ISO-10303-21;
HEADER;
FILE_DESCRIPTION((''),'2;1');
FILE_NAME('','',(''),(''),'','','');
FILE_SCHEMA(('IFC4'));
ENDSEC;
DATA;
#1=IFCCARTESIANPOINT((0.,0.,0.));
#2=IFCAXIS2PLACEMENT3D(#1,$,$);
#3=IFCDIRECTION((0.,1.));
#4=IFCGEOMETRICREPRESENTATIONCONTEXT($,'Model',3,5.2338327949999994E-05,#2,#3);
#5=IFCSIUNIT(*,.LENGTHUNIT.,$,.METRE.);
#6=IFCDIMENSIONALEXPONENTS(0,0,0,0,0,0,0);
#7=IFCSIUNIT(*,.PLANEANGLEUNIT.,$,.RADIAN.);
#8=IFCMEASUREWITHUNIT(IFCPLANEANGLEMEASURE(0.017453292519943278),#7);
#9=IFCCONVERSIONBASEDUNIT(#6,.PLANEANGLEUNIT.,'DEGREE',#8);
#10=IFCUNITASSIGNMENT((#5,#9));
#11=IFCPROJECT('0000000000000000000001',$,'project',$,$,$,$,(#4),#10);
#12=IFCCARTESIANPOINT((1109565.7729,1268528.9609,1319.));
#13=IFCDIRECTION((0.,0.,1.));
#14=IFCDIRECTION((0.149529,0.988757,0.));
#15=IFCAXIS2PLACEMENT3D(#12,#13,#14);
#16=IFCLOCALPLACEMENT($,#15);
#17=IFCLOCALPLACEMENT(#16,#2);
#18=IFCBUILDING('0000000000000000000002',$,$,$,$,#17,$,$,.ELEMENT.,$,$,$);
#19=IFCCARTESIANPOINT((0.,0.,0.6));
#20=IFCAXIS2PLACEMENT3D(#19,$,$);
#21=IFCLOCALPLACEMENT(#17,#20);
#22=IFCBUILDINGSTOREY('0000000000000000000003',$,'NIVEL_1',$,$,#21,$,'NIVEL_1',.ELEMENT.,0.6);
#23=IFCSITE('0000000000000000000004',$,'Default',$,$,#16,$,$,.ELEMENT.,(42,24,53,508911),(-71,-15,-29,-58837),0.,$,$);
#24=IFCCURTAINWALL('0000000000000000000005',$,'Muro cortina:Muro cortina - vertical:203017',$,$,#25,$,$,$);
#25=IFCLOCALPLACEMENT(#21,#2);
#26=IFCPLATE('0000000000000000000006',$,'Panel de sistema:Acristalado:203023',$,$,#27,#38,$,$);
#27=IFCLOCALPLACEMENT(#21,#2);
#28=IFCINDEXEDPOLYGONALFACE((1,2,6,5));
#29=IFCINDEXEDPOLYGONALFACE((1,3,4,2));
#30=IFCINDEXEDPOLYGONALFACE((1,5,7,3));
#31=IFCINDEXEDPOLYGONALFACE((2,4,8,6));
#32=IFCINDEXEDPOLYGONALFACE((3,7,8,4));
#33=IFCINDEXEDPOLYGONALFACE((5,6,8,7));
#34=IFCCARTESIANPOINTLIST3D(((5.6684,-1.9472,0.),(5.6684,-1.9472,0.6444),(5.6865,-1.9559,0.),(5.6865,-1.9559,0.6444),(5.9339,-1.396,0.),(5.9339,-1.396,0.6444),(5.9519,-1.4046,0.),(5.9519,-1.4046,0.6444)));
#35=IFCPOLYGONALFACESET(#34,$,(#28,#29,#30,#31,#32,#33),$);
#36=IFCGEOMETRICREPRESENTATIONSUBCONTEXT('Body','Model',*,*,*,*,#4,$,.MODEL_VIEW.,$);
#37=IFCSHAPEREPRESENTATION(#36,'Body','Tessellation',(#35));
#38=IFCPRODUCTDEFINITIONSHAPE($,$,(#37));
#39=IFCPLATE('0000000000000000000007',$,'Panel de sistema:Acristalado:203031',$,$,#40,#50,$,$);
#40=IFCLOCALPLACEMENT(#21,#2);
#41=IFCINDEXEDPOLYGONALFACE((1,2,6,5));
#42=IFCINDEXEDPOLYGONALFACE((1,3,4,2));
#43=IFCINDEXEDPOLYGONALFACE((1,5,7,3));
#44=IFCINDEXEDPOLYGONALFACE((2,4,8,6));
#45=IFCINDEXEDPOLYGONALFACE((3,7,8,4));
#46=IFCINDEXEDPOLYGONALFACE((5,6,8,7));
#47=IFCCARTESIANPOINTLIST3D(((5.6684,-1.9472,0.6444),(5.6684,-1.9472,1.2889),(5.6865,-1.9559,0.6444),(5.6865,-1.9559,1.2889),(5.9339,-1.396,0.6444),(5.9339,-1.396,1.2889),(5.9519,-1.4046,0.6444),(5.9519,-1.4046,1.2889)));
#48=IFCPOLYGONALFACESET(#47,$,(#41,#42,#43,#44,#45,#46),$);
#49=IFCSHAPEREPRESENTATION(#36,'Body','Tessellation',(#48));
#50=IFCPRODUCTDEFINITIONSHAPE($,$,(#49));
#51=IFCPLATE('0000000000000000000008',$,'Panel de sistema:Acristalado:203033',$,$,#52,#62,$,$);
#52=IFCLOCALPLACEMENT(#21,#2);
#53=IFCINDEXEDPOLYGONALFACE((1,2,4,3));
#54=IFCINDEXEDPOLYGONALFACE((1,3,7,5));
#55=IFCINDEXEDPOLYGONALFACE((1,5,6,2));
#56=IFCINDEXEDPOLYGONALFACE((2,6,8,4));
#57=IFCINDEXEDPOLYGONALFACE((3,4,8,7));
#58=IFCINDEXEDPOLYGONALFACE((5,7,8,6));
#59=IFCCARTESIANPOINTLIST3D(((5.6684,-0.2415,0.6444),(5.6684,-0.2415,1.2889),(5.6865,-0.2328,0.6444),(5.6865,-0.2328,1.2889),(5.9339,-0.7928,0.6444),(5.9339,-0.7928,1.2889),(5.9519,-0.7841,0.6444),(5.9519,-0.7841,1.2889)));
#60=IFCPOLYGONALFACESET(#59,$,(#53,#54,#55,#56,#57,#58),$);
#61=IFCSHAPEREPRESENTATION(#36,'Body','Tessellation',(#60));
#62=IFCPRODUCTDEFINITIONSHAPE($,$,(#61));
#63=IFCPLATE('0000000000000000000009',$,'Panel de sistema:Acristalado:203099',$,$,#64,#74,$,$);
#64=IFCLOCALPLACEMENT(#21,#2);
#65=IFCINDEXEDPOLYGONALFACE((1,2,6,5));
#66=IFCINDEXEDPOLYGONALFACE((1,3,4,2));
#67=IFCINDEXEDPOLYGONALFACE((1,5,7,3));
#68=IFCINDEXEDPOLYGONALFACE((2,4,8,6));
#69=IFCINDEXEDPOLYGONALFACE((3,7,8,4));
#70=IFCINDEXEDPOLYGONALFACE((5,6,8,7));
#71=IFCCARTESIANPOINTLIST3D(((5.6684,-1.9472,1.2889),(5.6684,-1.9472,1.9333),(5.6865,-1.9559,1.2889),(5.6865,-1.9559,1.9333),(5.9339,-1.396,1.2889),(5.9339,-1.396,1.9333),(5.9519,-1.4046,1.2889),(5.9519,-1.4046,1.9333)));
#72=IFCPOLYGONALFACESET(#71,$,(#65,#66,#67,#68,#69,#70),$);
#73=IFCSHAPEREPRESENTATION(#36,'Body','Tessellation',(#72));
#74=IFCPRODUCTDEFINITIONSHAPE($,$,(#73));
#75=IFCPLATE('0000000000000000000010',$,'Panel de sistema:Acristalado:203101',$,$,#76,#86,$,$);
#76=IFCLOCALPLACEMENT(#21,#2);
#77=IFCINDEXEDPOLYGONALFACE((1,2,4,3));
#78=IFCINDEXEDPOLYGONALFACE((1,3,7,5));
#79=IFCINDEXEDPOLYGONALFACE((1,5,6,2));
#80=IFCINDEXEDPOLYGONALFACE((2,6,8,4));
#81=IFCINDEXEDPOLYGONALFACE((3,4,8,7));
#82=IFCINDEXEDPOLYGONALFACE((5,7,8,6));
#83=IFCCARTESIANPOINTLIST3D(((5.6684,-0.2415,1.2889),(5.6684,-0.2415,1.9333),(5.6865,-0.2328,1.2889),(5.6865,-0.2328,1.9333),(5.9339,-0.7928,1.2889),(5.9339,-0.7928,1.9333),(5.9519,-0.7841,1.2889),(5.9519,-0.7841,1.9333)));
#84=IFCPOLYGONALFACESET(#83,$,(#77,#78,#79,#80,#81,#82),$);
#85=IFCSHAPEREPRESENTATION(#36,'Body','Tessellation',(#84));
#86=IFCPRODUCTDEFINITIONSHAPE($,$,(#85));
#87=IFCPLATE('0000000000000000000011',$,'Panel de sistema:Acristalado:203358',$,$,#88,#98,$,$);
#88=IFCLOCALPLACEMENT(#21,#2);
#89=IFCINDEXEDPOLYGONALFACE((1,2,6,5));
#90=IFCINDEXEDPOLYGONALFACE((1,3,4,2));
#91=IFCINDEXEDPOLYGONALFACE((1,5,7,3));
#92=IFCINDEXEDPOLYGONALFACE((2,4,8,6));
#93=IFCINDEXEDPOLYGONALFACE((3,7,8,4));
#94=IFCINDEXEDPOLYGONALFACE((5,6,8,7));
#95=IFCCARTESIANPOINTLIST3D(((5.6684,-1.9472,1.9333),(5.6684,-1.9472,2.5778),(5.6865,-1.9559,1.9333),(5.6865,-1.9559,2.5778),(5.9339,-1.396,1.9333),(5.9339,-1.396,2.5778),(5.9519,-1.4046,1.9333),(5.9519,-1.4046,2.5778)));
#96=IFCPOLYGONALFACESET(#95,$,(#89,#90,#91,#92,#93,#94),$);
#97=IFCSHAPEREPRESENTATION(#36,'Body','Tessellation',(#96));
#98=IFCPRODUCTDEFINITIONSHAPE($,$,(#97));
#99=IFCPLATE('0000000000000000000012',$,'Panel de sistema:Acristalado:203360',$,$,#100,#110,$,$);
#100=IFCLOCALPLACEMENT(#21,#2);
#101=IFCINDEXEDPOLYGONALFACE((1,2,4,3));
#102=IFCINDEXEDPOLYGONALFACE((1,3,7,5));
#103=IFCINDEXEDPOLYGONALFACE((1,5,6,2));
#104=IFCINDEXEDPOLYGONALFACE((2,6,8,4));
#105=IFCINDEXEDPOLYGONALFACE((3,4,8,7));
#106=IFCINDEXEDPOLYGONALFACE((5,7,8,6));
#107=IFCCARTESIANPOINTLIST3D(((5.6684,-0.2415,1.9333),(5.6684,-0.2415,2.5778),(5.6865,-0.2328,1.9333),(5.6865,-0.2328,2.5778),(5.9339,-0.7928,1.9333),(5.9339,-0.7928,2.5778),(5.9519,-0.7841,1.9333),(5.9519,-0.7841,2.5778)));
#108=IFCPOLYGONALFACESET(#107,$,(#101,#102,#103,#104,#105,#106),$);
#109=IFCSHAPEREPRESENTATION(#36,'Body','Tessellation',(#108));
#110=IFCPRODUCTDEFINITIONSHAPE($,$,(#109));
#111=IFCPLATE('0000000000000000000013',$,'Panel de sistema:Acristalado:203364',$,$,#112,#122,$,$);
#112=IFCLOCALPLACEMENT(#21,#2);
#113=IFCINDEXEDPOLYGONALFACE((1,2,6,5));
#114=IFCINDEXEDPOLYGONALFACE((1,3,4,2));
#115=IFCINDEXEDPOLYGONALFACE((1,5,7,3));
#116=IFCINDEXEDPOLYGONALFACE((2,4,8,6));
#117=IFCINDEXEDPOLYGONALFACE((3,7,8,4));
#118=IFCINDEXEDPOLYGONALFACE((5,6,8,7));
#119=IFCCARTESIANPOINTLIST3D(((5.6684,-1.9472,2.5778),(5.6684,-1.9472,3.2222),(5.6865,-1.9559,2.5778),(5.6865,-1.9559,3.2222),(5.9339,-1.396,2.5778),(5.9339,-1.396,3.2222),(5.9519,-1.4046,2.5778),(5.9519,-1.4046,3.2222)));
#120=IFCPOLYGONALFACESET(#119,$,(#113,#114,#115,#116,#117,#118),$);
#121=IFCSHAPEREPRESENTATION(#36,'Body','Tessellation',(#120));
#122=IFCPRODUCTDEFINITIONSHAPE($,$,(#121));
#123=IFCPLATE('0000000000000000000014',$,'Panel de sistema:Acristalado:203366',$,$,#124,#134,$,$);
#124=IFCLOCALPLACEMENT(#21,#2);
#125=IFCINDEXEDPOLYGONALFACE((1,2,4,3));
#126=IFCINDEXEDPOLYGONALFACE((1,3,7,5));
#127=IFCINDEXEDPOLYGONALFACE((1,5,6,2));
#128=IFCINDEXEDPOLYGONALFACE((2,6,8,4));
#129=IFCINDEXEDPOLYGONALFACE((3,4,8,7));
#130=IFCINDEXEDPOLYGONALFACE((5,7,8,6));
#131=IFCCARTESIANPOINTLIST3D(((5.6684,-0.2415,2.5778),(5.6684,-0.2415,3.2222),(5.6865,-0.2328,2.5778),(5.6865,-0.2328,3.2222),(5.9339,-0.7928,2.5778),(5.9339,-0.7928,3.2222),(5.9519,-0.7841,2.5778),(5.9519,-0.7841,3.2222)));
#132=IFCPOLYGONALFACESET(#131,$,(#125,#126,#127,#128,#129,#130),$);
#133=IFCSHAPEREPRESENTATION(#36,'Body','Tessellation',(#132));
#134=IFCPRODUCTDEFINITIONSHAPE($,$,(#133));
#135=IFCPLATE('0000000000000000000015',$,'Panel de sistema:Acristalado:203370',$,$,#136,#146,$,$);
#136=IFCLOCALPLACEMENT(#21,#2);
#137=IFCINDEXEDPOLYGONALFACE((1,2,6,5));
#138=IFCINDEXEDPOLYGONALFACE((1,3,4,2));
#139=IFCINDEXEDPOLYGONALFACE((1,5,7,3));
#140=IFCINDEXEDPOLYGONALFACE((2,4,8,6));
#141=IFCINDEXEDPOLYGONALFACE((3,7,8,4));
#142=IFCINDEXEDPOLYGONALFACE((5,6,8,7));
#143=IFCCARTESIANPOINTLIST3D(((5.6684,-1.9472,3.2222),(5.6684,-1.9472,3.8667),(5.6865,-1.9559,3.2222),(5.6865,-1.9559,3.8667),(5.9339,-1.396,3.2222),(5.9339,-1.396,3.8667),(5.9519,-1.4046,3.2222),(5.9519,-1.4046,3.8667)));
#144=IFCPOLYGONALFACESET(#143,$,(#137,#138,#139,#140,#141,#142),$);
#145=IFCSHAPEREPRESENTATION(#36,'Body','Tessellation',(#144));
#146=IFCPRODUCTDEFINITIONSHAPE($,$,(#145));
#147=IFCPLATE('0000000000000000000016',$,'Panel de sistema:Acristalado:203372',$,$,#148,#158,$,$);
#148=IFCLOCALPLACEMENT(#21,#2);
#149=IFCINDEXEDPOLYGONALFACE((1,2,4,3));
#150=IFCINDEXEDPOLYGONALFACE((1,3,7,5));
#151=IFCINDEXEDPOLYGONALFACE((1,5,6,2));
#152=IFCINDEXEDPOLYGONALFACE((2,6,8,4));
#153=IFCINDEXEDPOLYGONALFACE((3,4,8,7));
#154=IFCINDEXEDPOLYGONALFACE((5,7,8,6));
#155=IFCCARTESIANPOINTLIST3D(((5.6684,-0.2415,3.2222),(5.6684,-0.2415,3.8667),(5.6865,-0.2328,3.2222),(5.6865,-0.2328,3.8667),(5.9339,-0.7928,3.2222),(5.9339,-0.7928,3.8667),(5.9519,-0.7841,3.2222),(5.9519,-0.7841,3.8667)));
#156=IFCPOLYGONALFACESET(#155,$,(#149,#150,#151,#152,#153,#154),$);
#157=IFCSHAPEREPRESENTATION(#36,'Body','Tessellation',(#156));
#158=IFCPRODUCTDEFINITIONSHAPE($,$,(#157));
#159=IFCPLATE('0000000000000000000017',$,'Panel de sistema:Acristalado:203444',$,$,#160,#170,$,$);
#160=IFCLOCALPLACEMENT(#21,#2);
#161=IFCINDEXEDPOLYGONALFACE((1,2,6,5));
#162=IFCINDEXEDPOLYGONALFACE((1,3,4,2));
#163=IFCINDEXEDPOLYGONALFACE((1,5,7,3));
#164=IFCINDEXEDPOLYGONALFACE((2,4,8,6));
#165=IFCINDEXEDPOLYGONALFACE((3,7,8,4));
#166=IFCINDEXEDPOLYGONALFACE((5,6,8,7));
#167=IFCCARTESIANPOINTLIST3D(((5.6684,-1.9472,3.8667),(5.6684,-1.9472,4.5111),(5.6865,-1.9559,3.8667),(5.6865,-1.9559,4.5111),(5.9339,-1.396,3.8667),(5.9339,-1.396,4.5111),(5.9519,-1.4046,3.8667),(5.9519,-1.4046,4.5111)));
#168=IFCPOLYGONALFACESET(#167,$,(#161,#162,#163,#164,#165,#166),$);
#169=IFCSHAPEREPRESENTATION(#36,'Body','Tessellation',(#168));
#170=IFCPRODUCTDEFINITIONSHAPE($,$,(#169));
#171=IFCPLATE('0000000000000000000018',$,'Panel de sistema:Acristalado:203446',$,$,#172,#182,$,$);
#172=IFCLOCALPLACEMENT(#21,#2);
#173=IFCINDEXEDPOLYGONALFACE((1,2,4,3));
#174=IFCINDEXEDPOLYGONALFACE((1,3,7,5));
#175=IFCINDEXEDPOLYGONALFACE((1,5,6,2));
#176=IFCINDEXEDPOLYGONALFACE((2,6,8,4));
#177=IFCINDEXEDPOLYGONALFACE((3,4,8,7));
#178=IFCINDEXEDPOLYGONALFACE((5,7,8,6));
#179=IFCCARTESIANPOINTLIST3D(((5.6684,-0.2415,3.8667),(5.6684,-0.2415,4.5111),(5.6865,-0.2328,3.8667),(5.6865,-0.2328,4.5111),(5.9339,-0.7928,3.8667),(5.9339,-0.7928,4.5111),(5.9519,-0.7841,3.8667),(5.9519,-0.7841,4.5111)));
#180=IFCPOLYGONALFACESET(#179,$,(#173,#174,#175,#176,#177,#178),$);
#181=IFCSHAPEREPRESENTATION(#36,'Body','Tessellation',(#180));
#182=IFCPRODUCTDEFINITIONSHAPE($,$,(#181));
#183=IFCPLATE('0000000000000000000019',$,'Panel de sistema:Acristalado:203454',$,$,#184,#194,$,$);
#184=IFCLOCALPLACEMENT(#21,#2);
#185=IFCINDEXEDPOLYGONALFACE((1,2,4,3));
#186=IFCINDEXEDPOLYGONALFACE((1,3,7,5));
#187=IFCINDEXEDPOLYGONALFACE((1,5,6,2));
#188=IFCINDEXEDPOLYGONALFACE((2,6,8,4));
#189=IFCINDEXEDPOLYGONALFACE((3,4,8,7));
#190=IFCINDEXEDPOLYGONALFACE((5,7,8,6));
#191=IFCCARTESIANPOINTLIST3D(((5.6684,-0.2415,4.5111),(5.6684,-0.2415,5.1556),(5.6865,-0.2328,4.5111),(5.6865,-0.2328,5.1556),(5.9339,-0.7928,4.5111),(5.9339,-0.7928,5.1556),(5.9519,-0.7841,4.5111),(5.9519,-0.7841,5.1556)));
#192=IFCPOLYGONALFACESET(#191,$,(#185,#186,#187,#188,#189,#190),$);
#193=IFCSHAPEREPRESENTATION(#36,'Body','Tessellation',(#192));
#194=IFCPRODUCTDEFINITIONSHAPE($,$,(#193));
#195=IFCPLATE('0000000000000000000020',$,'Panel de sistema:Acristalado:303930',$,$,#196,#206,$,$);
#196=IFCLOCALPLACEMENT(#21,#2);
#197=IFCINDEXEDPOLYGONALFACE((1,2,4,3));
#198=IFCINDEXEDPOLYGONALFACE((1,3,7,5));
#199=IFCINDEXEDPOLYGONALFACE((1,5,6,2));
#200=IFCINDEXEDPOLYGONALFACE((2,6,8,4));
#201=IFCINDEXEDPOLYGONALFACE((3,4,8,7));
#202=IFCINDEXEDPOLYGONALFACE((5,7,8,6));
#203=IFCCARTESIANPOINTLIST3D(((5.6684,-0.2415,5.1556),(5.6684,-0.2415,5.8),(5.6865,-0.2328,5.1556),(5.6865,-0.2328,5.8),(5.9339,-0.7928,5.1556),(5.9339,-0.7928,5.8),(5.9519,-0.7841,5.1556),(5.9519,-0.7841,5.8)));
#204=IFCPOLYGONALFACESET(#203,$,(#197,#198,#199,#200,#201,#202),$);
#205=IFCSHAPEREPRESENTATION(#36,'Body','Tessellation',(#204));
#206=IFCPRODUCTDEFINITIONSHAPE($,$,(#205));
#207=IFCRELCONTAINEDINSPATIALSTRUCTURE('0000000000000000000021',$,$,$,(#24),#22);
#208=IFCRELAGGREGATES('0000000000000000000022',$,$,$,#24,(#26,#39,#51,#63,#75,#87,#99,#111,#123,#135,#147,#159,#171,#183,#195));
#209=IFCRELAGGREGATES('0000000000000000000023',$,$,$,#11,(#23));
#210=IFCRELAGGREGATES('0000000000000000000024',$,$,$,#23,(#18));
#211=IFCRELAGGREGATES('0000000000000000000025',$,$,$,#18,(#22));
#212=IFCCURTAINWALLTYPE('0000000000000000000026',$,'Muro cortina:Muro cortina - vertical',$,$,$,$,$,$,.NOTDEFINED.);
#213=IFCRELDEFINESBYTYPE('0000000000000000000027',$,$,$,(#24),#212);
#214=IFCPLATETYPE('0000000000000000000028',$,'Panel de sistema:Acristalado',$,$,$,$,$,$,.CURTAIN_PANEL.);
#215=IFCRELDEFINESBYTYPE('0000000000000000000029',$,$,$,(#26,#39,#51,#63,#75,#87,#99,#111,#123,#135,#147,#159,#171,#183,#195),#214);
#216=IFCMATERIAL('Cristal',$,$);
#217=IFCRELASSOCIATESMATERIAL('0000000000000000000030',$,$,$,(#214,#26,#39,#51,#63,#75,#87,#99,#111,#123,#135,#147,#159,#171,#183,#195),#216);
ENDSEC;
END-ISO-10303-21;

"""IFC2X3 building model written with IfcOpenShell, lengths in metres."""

from ifc_helpers import new_model, entity, si_unit, converted_unit, direction, frame, frame_2d, origin, place, context, subcontext, project, spatial, rectangle, extrude, source, transform, mapped, material, type_object, type_shapes, element, aggregate, save


model = new_model("IFC2X3")

# Units and contexts
model_context = context("Model", 3, precision=5.2338327949999994e-05, world=origin(), true_north=direction((0.0, 1.0)))
body_context = subcontext(model_context, "Body", "Model", "MODEL_VIEW")
ifc_project = project(units=[si_unit("LENGTHUNIT", "METRE"), converted_unit("PLANEANGLEUNIT", "DEGREE", entity("IfcPlaneAngleMeasure", 0.017453292519943278), si_unit("PLANEANGLEUNIT", "RADIAN"), dimensions=[0, 0, 0, 0, 0, 0, 0])], contexts=[model_context])

# Site, building, storey
site_placement = place(None, frame((1109565.7729, 1268528.9609, 1319.0), z_axis=(0.0, 0.0, 1.0), x_axis=(0.149529, 0.988757, 0.0)))
site = spatial("IfcSite", under=ifc_project, at=site_placement, Name="Default", CompositionType="ELEMENT", RefLatitude=(42, 24, 53, 508911), RefLongitude=(-71, -15, -29, -58837), RefElevation=0.0)
building_placement = place(site_placement, origin())
building = spatial("IfcBuilding", under=site, at=building_placement, CompositionType="ELEMENT")
storey_placement = place(building_placement, frame((0.0, 0.0, 0.6)))
storey = spatial("IfcBuildingStorey", under=building, at=storey_placement, Name="NIVEL_1", LongName="NIVEL_1", CompositionType="ELEMENT", Elevation=0.6)

# Curtain wall, plates
curtain_wall_type = type_object("IfcCurtainWallType", Name="Muro cortina:Muro cortina - vertical", PredefinedType="NOTDEFINED")
curtain_wall_placement = place(storey_placement, frame((0.0, 0.0, -0.6)))
curtain_wall = element("IfcCurtainWall", 1, at=curtain_wall_placement, inside=storey, type_object=curtain_wall_type, Name="Muro cortina:Muro cortina - vertical:203017")
ifc_material = material(Name="Cristal")
plate_type = type_object("IfcPlateType", Name="Panel de sistema:Acristalado", PredefinedType="CURTAIN_PANEL", material=ifc_material)
shared_shape = source(origin(), body_context, "Body", "SweptSolid", [
    extrude(rectangle(XDim=0.02, YDim=0.6119, at=frame_2d((0.0, 0.0), x_axis=(1.0, 0.0))), frame((0.0, 0.0, 0.0), z_axis=(0.0, 0.0, 1.0), x_axis=(0.0, 1.0, 0.0)), (0.0, 0.0, 1.0), 0.6444),
])
type_shapes(plate_type, [shared_shape])
plate_1_placement = place(curtain_wall_placement, frame((5.8102, -1.6759, 0.6), z_axis=(0.0, 0.0, 1.0), x_axis=(0.433884, 0.900969, 0.0)))
plate_1 = element("IfcPlate", 2, at=plate_1_placement, type_object=plate_type, material=ifc_material, Name="Panel de sistema:Acristalado:203023", context=body_context, shape_type="MappedRepresentation", body=[
    mapped(shared_shape, transform((0.0, 0.0, 0.0), scale=1.0)),
])
plate_2_placement = place(curtain_wall_placement, frame((5.8102, -1.6759, 1.2444), z_axis=(0.0, 0.0, 1.0), x_axis=(0.433884, 0.900969, 0.0)))
plate_2 = element("IfcPlate", 3, at=plate_2_placement, type_object=plate_type, material=ifc_material, Name="Panel de sistema:Acristalado:203031", context=body_context, shape_type="MappedRepresentation", body=[
    mapped(shared_shape, transform((0.0, 0.0, 0.0), scale=1.0)),
])
plate_3_placement = place(curtain_wall_placement, frame((5.8102, -0.5128, 1.2444), z_axis=(0.0, 0.0, 1.0), x_axis=(-0.433884, 0.900969, 0.0)))
plate_3 = element("IfcPlate", 4, at=plate_3_placement, type_object=plate_type, material=ifc_material, Name="Panel de sistema:Acristalado:203033", context=body_context, shape_type="MappedRepresentation", body=[
    mapped(shared_shape, transform((0.0, 0.0, 0.0), scale=1.0)),
])
plate_4_placement = place(curtain_wall_placement, frame((5.8102, -1.6759, 1.8889), z_axis=(0.0, 0.0, 1.0), x_axis=(0.433884, 0.900969, 0.0)))
plate_4 = element("IfcPlate", 5, at=plate_4_placement, type_object=plate_type, material=ifc_material, Name="Panel de sistema:Acristalado:203099", context=body_context, shape_type="MappedRepresentation", body=[
    mapped(shared_shape, transform((0.0, 0.0, 0.0), scale=1.0)),
])
plate_5_placement = place(curtain_wall_placement, frame((5.8102, -0.5128, 1.8889), z_axis=(0.0, 0.0, 1.0), x_axis=(-0.433884, 0.900969, 0.0)))
plate_5 = element("IfcPlate", 6, at=plate_5_placement, type_object=plate_type, material=ifc_material, Name="Panel de sistema:Acristalado:203101", context=body_context, shape_type="MappedRepresentation", body=[
    mapped(shared_shape, transform((0.0, 0.0, 0.0), scale=1.0)),
])
plate_6_placement = place(curtain_wall_placement, frame((5.8102, -1.6759, 2.5333), z_axis=(0.0, 0.0, 1.0), x_axis=(0.433884, 0.900969, 0.0)))
plate_6 = element("IfcPlate", 7, at=plate_6_placement, type_object=plate_type, material=ifc_material, Name="Panel de sistema:Acristalado:203358", context=body_context, shape_type="MappedRepresentation", body=[
    mapped(shared_shape, transform((0.0, 0.0, 0.0), scale=1.0)),
])
plate_7_placement = place(curtain_wall_placement, frame((5.8102, -0.5128, 2.5333), z_axis=(0.0, 0.0, 1.0), x_axis=(-0.433884, 0.900969, 0.0)))
plate_7 = element("IfcPlate", 8, at=plate_7_placement, type_object=plate_type, material=ifc_material, Name="Panel de sistema:Acristalado:203360", context=body_context, shape_type="MappedRepresentation", body=[
    mapped(shared_shape, transform((0.0, 0.0, 0.0), scale=1.0)),
])
plate_8_placement = place(curtain_wall_placement, frame((5.8102, -1.6759, 3.1778), z_axis=(0.0, 0.0, 1.0), x_axis=(0.433884, 0.900969, 0.0)))
plate_8 = element("IfcPlate", 9, at=plate_8_placement, type_object=plate_type, material=ifc_material, Name="Panel de sistema:Acristalado:203364", context=body_context, shape_type="MappedRepresentation", body=[
    mapped(shared_shape, transform((0.0, 0.0, 0.0), scale=1.0)),
])
plate_9_placement = place(curtain_wall_placement, frame((5.8102, -0.5128, 3.1778), z_axis=(0.0, 0.0, 1.0), x_axis=(-0.433884, 0.900969, 0.0)))
plate_9 = element("IfcPlate", 10, at=plate_9_placement, type_object=plate_type, material=ifc_material, Name="Panel de sistema:Acristalado:203366", context=body_context, shape_type="MappedRepresentation", body=[
    mapped(shared_shape, transform((0.0, 0.0, 0.0), scale=1.0)),
])
plate_10_placement = place(curtain_wall_placement, frame((5.8102, -1.6759, 3.8222), z_axis=(0.0, 0.0, 1.0), x_axis=(0.433884, 0.900969, 0.0)))
plate_10 = element("IfcPlate", 11, at=plate_10_placement, type_object=plate_type, material=ifc_material, Name="Panel de sistema:Acristalado:203370", context=body_context, shape_type="MappedRepresentation", body=[
    mapped(shared_shape, transform((0.0, 0.0, 0.0), scale=1.0)),
])
plate_11_placement = place(curtain_wall_placement, frame((5.8102, -0.5128, 3.8222), z_axis=(0.0, 0.0, 1.0), x_axis=(-0.433884, 0.900969, 0.0)))
plate_11 = element("IfcPlate", 12, at=plate_11_placement, type_object=plate_type, material=ifc_material, Name="Panel de sistema:Acristalado:203372", context=body_context, shape_type="MappedRepresentation", body=[
    mapped(shared_shape, transform((0.0, 0.0, 0.0), scale=1.0)),
])
plate_12_placement = place(curtain_wall_placement, frame((5.8102, -1.6759, 4.4667), z_axis=(0.0, 0.0, 1.0), x_axis=(0.433884, 0.900969, 0.0)))
plate_12 = element("IfcPlate", 13, at=plate_12_placement, type_object=plate_type, material=ifc_material, Name="Panel de sistema:Acristalado:203444", context=body_context, shape_type="MappedRepresentation", body=[
    mapped(shared_shape, transform((0.0, 0.0, 0.0), scale=1.0)),
])
plate_13_placement = place(curtain_wall_placement, frame((5.8102, -0.5128, 4.4667), z_axis=(0.0, 0.0, 1.0), x_axis=(-0.433884, 0.900969, 0.0)))
plate_13 = element("IfcPlate", 14, at=plate_13_placement, type_object=plate_type, material=ifc_material, Name="Panel de sistema:Acristalado:203446", context=body_context, shape_type="MappedRepresentation", body=[
    mapped(shared_shape, transform((0.0, 0.0, 0.0), scale=1.0)),
])
plate_14_placement = place(curtain_wall_placement, frame((5.8102, -0.5128, 5.1111), z_axis=(0.0, 0.0, 1.0), x_axis=(-0.433884, 0.900969, 0.0)))
plate_14 = element("IfcPlate", 15, at=plate_14_placement, type_object=plate_type, material=ifc_material, Name="Panel de sistema:Acristalado:203454", context=body_context, shape_type="MappedRepresentation", body=[
    mapped(shared_shape, transform((0.0, 0.0, 0.0), scale=1.0)),
])
plate_15_placement = place(curtain_wall_placement, frame((5.8102, -0.5128, 5.7556), z_axis=(0.0, 0.0, 1.0), x_axis=(-0.433884, 0.900969, 0.0)))
plate_15 = element("IfcPlate", 16, at=plate_15_placement, type_object=plate_type, material=ifc_material, Name="Panel de sistema:Acristalado:303930", context=body_context, shape_type="MappedRepresentation", body=[
    mapped(shared_shape, transform((0.0, 0.0, 0.0), scale=1.0)),
])
aggregate(curtain_wall, [plate_1, plate_2, plate_3, plate_4, plate_5, plate_6, plate_7, plate_8, plate_9, plate_10, plate_11, plate_12, plate_13, plate_14, plate_15])

save(model, "model.ifc")
